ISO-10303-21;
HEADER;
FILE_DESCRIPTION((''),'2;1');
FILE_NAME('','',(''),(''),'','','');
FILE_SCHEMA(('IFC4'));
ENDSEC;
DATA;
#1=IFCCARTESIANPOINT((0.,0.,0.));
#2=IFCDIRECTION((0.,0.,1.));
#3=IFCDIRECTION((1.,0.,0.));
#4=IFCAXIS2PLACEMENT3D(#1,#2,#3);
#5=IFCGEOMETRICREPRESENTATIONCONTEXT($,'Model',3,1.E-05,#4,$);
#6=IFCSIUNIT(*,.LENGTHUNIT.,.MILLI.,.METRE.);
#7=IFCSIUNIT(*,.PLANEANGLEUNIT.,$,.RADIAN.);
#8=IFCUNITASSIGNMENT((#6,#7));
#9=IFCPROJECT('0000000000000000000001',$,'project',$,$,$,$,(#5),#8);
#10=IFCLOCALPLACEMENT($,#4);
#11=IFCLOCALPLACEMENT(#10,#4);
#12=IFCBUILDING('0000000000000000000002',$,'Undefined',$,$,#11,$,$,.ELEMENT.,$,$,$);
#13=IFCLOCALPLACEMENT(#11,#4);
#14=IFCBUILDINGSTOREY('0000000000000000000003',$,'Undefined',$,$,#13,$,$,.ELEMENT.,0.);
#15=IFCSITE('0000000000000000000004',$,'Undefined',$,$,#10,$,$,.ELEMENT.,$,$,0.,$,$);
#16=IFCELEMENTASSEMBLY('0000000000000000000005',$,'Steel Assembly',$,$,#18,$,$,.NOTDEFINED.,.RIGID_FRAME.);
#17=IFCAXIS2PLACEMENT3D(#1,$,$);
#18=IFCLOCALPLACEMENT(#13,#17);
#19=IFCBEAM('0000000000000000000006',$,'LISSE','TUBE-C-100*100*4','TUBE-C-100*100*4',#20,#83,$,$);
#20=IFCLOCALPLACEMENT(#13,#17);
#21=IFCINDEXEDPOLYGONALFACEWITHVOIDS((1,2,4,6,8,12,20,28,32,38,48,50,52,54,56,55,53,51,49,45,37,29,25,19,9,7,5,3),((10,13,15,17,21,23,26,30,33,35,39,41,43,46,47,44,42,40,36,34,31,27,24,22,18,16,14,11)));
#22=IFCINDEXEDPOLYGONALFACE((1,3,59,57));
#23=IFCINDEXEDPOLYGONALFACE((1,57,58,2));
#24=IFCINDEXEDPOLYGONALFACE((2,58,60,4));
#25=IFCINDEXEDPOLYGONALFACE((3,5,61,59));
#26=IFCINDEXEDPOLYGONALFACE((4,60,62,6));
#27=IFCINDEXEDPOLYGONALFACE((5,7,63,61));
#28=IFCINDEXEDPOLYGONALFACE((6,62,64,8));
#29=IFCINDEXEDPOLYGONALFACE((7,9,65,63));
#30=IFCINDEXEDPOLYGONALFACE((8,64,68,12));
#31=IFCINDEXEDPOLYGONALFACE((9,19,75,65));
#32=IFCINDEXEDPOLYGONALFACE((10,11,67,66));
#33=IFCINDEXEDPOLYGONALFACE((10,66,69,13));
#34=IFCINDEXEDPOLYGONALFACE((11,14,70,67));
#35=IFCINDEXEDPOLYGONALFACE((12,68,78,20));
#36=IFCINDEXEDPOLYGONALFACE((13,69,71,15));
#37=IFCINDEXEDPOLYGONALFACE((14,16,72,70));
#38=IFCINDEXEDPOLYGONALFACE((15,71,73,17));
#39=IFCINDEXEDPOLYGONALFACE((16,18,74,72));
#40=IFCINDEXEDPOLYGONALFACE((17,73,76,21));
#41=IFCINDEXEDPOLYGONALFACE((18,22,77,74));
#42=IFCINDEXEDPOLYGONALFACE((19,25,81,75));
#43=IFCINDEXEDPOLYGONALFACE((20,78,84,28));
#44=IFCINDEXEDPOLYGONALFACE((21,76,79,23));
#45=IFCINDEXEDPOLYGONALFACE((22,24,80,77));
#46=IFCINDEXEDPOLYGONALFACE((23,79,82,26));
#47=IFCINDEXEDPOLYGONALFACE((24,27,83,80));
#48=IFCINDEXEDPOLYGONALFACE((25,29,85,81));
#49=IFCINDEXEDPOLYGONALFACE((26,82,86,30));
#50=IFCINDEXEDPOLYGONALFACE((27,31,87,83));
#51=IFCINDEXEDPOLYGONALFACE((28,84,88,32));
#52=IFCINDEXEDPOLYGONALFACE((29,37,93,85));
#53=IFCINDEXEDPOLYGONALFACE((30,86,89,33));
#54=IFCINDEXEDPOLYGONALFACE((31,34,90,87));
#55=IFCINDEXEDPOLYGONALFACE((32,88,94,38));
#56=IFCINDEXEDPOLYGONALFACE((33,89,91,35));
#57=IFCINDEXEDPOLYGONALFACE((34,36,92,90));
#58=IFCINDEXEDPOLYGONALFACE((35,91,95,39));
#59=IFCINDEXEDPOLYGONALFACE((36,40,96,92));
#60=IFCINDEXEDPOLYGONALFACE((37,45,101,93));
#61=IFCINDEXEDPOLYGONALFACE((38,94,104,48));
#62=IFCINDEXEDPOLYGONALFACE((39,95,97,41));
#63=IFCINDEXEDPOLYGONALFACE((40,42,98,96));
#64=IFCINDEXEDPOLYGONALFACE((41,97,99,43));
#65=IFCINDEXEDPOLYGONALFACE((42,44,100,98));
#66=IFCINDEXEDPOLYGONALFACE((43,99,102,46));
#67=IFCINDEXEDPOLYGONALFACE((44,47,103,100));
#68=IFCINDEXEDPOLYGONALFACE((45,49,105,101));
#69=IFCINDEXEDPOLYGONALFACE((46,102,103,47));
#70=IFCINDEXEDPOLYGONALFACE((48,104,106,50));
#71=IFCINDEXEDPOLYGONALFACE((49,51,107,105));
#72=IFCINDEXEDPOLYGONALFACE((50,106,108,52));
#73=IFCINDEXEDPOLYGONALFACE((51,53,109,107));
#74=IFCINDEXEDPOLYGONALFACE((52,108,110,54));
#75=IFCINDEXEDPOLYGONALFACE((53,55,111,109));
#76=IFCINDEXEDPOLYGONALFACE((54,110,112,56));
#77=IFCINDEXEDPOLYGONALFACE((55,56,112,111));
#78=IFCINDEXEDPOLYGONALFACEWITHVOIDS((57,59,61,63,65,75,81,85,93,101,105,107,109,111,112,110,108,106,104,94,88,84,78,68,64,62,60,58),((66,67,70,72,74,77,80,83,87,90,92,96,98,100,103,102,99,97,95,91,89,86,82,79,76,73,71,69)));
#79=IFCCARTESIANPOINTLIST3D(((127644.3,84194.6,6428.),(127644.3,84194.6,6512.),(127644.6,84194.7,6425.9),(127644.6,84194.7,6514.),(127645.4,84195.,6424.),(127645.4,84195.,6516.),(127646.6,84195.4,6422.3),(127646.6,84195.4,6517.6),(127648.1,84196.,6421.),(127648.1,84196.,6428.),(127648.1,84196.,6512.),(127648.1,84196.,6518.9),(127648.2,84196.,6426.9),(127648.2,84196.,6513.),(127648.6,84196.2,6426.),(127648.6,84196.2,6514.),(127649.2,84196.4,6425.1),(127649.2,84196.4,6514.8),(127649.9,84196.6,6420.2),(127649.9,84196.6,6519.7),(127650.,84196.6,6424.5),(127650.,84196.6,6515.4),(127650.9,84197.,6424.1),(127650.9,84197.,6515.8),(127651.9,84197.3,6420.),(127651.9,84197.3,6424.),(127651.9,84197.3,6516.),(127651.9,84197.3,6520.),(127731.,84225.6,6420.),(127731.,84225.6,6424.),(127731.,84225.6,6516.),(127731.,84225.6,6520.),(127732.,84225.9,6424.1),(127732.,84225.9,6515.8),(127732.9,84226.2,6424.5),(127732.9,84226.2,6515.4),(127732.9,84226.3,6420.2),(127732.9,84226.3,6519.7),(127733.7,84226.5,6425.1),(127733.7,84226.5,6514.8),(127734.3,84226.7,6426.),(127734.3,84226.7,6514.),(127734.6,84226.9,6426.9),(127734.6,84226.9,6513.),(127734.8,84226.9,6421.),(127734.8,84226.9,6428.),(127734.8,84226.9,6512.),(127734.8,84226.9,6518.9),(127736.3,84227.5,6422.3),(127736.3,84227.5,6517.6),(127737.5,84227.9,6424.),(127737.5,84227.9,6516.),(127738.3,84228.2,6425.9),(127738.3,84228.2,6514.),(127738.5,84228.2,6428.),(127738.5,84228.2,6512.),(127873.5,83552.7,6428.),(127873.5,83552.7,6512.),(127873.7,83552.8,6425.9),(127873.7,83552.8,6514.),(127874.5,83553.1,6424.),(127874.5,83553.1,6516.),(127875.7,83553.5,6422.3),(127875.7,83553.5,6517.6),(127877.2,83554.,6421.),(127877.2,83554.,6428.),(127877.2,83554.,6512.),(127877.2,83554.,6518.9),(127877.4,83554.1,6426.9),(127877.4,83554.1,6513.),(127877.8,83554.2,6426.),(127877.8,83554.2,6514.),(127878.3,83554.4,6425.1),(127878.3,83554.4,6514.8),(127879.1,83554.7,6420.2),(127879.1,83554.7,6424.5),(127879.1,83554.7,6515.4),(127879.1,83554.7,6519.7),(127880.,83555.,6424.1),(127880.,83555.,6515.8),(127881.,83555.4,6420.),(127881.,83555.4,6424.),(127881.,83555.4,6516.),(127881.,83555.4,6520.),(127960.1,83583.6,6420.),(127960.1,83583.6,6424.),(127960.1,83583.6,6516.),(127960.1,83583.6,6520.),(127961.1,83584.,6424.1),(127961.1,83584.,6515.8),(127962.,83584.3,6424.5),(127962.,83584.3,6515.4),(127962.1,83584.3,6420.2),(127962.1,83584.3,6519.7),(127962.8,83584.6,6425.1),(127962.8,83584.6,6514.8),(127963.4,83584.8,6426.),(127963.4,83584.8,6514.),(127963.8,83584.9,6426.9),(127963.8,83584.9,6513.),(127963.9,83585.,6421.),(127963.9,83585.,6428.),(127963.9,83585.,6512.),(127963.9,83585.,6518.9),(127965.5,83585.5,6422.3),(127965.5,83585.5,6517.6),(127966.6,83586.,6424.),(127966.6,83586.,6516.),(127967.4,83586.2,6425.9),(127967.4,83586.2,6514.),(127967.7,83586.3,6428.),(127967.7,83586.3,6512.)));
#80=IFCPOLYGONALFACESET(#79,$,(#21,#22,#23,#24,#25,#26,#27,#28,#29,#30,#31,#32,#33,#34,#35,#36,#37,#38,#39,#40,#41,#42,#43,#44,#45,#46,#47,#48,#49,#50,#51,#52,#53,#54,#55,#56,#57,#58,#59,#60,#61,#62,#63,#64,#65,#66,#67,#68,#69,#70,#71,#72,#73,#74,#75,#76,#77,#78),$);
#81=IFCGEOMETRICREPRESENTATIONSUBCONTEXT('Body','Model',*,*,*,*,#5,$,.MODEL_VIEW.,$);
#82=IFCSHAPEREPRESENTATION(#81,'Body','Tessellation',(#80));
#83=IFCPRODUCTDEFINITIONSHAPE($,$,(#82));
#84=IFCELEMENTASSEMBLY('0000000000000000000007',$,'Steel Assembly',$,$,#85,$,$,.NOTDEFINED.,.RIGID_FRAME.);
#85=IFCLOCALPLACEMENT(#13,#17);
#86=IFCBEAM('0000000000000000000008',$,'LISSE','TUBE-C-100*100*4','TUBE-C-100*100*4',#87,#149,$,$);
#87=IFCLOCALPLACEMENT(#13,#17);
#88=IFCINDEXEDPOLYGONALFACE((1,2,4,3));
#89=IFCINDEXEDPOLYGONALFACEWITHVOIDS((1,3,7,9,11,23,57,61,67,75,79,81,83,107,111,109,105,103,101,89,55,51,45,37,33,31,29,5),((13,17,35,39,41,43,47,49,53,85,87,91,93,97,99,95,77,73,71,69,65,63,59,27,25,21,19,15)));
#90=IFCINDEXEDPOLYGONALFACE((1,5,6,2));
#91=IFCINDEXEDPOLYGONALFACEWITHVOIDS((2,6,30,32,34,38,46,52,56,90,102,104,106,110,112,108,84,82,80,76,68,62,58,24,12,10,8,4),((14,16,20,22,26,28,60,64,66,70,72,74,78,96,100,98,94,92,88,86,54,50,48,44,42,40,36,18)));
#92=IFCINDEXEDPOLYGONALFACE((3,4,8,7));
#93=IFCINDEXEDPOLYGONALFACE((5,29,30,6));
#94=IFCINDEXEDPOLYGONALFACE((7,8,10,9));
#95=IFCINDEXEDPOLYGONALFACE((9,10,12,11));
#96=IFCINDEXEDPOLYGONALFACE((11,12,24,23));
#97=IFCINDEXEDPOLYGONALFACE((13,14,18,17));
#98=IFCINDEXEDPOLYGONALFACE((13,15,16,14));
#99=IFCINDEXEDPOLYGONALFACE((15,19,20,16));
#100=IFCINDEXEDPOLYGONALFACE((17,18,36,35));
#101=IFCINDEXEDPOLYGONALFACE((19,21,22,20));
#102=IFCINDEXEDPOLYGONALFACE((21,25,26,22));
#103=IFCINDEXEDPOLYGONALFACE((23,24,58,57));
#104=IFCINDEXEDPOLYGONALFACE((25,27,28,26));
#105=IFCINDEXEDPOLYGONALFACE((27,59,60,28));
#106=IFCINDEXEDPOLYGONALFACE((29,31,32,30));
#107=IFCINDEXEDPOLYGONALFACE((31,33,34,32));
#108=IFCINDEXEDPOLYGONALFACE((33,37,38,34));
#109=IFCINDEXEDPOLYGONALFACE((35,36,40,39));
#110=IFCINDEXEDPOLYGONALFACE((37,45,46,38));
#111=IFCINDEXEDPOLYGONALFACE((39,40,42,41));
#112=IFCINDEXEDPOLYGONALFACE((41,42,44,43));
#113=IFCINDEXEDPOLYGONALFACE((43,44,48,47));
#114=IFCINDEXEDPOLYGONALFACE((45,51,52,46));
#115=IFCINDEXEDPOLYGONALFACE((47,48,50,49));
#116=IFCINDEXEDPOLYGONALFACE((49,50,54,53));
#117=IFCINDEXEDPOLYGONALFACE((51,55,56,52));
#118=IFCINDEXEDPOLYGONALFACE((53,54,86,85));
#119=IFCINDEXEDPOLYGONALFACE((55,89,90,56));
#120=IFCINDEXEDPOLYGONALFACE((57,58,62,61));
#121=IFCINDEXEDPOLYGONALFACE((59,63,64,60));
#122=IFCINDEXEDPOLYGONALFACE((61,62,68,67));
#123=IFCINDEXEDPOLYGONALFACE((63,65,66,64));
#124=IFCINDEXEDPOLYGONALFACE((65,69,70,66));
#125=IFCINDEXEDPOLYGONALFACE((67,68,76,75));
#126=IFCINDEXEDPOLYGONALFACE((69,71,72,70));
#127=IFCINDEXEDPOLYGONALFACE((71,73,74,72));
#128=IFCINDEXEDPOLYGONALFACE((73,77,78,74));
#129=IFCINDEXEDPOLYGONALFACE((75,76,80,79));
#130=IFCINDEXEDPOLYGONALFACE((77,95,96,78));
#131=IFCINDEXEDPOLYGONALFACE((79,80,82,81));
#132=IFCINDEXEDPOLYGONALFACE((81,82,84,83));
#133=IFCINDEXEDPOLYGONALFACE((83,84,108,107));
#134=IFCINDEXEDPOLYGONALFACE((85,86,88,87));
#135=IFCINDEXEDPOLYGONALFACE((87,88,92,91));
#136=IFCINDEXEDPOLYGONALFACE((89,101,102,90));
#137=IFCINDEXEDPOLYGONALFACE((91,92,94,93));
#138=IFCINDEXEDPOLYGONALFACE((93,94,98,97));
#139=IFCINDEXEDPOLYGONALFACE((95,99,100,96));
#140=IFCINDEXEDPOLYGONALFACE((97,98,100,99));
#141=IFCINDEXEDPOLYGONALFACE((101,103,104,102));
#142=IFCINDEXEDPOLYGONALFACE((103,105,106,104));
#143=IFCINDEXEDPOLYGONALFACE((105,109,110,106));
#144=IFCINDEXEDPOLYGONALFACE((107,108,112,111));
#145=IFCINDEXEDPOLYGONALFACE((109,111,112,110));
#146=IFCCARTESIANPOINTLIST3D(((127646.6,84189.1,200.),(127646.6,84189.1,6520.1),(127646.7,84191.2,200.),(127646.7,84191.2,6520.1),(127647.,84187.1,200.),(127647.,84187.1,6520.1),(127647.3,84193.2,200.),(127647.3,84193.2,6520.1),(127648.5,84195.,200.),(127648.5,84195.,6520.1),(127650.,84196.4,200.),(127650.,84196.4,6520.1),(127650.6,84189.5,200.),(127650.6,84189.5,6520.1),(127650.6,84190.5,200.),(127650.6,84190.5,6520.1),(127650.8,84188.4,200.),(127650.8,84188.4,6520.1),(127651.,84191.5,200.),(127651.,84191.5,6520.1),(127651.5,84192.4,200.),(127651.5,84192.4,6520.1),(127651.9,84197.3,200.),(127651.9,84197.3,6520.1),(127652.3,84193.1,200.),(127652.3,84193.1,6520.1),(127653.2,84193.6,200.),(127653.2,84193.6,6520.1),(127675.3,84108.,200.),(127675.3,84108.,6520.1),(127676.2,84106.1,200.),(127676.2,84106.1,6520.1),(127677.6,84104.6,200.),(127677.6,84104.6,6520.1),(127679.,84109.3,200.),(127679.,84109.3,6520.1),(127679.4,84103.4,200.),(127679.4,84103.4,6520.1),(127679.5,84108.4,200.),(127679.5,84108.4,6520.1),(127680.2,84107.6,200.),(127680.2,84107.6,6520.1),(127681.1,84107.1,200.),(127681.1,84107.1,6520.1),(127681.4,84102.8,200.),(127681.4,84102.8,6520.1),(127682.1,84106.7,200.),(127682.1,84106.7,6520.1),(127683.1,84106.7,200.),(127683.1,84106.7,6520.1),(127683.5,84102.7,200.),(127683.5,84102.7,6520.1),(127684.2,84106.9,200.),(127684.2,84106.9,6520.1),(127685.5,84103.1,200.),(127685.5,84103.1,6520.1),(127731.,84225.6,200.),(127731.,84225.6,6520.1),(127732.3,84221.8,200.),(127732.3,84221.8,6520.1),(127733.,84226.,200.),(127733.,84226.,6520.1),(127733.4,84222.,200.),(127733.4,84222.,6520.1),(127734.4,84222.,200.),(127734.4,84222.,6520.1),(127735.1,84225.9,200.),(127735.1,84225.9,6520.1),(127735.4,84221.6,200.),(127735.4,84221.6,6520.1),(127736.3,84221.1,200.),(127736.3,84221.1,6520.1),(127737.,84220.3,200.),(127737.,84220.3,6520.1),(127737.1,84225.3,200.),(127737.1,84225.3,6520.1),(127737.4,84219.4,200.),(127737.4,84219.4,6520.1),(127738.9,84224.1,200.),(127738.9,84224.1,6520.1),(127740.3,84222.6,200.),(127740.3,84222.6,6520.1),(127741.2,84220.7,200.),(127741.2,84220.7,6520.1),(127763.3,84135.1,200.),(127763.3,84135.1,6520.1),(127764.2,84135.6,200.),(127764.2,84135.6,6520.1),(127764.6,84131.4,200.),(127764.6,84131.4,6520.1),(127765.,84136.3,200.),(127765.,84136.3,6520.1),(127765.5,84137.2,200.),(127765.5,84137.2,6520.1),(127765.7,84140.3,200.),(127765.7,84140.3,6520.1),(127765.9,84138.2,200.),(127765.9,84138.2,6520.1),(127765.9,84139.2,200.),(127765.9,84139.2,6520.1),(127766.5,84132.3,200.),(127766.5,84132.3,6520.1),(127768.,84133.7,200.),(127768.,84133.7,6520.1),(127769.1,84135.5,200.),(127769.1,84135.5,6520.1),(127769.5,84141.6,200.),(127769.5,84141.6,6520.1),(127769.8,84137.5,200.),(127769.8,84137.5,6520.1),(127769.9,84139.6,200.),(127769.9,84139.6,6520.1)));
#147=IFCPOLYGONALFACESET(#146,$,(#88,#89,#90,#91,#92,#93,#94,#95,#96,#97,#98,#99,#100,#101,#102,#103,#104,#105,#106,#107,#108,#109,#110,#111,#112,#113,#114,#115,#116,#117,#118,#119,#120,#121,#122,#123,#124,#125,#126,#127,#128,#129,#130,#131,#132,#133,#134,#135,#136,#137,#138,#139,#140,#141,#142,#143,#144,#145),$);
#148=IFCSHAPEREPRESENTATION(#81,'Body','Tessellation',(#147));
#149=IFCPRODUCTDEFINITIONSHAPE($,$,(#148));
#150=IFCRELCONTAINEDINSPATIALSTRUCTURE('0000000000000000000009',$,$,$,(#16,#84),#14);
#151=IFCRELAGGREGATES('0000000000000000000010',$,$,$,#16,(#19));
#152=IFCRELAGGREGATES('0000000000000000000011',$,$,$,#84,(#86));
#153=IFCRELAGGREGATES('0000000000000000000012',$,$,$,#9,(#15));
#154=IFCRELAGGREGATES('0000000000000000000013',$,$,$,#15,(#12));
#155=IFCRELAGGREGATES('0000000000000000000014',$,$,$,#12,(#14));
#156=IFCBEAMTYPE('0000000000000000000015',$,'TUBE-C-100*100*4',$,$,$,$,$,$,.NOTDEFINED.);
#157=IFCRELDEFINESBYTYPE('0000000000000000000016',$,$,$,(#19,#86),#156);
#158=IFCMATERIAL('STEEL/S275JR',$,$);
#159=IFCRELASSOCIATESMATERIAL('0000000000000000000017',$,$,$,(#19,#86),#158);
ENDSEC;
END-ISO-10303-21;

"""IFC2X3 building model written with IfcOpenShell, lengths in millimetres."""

from ifc_helpers import new_model, si_unit, frame, origin_with_axes, origin_2d_with_axis, place, context, subcontext, project, spatial, hollow_rectangle, extrude, material, type_object, element, aggregate, save


model = new_model("IFC2X3")

# Units and contexts
model_context = context("Model", 3, precision=1e-05, world=origin_with_axes())
body_context = subcontext(model_context, "Body", "Model", "MODEL_VIEW")
ifc_project = project(units=[si_unit("LENGTHUNIT", "METRE", prefix="MILLI"), si_unit("PLANEANGLEUNIT", "RADIAN")], contexts=[model_context])

# Site, building, storey
site_placement = place(None, origin_with_axes())
site = spatial("IfcSite", under=ifc_project, at=site_placement, Name="Undefined", CompositionType="ELEMENT", RefElevation=0.0)
building_placement = place(site_placement, origin_with_axes())
building = spatial("IfcBuilding", under=site, at=building_placement, Name="Undefined", CompositionType="ELEMENT")
storey_placement = place(building_placement, origin_with_axes())
storey = spatial("IfcBuildingStorey", under=building, at=storey_placement, Name="Undefined", CompositionType="ELEMENT", Elevation=0.0)

# Shared definitions
ifc_material = material(Name="STEEL/S275JR")

# Element assemblies, beams
beam_type_1 = type_object("IfcBeamType", Name="TUBE-C-100*100*4", PredefinedType="NOTDEFINED")
assembly_1_placement = place(storey_placement, origin_with_axes())
assembly_1 = element("IfcElementAssembly", 1, at=assembly_1_placement, inside=storey, Name="Steel Assembly", AssemblyPlace="NOTDEFINED", PredefinedType="RIGID_FRAME")
beam_1_placement = place(assembly_1_placement, frame((127920.6, 83569.5, 6470.0), z_axis=(0.941802, 0.336168, 0.0), x_axis=(-0.336168, 0.941802, 0.0)))
beam_1 = element("IfcBeam", 2, at=beam_1_placement, type_object=beam_type_1, material=ifc_material, Name="LISSE", Description="TUBE-C-100*100*4", ObjectType="TUBE-C-100*100*4", context=body_context, shape_type="SweptSolid", body=[
    extrude(hollow_rectangle(XDim=100.0, YDim=100.0, WallThickness=4.0, InnerFilletRadius=4.0, OuterFilletRadius=8.0, at=origin_2d_with_axis()), frame((681.6, 0.0, 0.0), z_axis=(-1.0, 0.0, 0.0), x_axis=(0.0, -1.0, 0.0)), (0.0, 0.0, 1.0), 681.6),
])
aggregate(assembly_1, [beam_1])
assembly_2_placement = place(storey_placement, origin_with_axes())
assembly_2 = element("IfcElementAssembly", 3, at=assembly_2_placement, inside=storey, Name="Steel Assembly", AssemblyPlace="NOTDEFINED", PredefinedType="RIGID_FRAME")
beam_2_placement = place(assembly_2_placement, frame((127708.2, 84164.3, 6520.1), z_axis=(0.941802, 0.336168, 0.0), x_axis=(0.0, 0.0, -1.0)))
beam_2 = element("IfcBeam", 4, at=beam_2_placement, type_object=beam_type_1, material=ifc_material, Name="LISSE", Description="TUBE-C-100*100*4", ObjectType="TUBE-C-100*100*4", context=body_context, shape_type="SweptSolid", body=[
    extrude(hollow_rectangle(XDim=100.0, YDim=100.0, WallThickness=4.0, InnerFilletRadius=4.0, OuterFilletRadius=8.0, at=origin_2d_with_axis()), frame((6320.1, 0.0, 0.0), z_axis=(-1.0, 0.0, 0.0), x_axis=(0.0, -1.0, 0.0)), (0.0, 0.0, 1.0), 6320.1),
])
aggregate(assembly_2, [beam_2])

save(model, "model.ifc")
